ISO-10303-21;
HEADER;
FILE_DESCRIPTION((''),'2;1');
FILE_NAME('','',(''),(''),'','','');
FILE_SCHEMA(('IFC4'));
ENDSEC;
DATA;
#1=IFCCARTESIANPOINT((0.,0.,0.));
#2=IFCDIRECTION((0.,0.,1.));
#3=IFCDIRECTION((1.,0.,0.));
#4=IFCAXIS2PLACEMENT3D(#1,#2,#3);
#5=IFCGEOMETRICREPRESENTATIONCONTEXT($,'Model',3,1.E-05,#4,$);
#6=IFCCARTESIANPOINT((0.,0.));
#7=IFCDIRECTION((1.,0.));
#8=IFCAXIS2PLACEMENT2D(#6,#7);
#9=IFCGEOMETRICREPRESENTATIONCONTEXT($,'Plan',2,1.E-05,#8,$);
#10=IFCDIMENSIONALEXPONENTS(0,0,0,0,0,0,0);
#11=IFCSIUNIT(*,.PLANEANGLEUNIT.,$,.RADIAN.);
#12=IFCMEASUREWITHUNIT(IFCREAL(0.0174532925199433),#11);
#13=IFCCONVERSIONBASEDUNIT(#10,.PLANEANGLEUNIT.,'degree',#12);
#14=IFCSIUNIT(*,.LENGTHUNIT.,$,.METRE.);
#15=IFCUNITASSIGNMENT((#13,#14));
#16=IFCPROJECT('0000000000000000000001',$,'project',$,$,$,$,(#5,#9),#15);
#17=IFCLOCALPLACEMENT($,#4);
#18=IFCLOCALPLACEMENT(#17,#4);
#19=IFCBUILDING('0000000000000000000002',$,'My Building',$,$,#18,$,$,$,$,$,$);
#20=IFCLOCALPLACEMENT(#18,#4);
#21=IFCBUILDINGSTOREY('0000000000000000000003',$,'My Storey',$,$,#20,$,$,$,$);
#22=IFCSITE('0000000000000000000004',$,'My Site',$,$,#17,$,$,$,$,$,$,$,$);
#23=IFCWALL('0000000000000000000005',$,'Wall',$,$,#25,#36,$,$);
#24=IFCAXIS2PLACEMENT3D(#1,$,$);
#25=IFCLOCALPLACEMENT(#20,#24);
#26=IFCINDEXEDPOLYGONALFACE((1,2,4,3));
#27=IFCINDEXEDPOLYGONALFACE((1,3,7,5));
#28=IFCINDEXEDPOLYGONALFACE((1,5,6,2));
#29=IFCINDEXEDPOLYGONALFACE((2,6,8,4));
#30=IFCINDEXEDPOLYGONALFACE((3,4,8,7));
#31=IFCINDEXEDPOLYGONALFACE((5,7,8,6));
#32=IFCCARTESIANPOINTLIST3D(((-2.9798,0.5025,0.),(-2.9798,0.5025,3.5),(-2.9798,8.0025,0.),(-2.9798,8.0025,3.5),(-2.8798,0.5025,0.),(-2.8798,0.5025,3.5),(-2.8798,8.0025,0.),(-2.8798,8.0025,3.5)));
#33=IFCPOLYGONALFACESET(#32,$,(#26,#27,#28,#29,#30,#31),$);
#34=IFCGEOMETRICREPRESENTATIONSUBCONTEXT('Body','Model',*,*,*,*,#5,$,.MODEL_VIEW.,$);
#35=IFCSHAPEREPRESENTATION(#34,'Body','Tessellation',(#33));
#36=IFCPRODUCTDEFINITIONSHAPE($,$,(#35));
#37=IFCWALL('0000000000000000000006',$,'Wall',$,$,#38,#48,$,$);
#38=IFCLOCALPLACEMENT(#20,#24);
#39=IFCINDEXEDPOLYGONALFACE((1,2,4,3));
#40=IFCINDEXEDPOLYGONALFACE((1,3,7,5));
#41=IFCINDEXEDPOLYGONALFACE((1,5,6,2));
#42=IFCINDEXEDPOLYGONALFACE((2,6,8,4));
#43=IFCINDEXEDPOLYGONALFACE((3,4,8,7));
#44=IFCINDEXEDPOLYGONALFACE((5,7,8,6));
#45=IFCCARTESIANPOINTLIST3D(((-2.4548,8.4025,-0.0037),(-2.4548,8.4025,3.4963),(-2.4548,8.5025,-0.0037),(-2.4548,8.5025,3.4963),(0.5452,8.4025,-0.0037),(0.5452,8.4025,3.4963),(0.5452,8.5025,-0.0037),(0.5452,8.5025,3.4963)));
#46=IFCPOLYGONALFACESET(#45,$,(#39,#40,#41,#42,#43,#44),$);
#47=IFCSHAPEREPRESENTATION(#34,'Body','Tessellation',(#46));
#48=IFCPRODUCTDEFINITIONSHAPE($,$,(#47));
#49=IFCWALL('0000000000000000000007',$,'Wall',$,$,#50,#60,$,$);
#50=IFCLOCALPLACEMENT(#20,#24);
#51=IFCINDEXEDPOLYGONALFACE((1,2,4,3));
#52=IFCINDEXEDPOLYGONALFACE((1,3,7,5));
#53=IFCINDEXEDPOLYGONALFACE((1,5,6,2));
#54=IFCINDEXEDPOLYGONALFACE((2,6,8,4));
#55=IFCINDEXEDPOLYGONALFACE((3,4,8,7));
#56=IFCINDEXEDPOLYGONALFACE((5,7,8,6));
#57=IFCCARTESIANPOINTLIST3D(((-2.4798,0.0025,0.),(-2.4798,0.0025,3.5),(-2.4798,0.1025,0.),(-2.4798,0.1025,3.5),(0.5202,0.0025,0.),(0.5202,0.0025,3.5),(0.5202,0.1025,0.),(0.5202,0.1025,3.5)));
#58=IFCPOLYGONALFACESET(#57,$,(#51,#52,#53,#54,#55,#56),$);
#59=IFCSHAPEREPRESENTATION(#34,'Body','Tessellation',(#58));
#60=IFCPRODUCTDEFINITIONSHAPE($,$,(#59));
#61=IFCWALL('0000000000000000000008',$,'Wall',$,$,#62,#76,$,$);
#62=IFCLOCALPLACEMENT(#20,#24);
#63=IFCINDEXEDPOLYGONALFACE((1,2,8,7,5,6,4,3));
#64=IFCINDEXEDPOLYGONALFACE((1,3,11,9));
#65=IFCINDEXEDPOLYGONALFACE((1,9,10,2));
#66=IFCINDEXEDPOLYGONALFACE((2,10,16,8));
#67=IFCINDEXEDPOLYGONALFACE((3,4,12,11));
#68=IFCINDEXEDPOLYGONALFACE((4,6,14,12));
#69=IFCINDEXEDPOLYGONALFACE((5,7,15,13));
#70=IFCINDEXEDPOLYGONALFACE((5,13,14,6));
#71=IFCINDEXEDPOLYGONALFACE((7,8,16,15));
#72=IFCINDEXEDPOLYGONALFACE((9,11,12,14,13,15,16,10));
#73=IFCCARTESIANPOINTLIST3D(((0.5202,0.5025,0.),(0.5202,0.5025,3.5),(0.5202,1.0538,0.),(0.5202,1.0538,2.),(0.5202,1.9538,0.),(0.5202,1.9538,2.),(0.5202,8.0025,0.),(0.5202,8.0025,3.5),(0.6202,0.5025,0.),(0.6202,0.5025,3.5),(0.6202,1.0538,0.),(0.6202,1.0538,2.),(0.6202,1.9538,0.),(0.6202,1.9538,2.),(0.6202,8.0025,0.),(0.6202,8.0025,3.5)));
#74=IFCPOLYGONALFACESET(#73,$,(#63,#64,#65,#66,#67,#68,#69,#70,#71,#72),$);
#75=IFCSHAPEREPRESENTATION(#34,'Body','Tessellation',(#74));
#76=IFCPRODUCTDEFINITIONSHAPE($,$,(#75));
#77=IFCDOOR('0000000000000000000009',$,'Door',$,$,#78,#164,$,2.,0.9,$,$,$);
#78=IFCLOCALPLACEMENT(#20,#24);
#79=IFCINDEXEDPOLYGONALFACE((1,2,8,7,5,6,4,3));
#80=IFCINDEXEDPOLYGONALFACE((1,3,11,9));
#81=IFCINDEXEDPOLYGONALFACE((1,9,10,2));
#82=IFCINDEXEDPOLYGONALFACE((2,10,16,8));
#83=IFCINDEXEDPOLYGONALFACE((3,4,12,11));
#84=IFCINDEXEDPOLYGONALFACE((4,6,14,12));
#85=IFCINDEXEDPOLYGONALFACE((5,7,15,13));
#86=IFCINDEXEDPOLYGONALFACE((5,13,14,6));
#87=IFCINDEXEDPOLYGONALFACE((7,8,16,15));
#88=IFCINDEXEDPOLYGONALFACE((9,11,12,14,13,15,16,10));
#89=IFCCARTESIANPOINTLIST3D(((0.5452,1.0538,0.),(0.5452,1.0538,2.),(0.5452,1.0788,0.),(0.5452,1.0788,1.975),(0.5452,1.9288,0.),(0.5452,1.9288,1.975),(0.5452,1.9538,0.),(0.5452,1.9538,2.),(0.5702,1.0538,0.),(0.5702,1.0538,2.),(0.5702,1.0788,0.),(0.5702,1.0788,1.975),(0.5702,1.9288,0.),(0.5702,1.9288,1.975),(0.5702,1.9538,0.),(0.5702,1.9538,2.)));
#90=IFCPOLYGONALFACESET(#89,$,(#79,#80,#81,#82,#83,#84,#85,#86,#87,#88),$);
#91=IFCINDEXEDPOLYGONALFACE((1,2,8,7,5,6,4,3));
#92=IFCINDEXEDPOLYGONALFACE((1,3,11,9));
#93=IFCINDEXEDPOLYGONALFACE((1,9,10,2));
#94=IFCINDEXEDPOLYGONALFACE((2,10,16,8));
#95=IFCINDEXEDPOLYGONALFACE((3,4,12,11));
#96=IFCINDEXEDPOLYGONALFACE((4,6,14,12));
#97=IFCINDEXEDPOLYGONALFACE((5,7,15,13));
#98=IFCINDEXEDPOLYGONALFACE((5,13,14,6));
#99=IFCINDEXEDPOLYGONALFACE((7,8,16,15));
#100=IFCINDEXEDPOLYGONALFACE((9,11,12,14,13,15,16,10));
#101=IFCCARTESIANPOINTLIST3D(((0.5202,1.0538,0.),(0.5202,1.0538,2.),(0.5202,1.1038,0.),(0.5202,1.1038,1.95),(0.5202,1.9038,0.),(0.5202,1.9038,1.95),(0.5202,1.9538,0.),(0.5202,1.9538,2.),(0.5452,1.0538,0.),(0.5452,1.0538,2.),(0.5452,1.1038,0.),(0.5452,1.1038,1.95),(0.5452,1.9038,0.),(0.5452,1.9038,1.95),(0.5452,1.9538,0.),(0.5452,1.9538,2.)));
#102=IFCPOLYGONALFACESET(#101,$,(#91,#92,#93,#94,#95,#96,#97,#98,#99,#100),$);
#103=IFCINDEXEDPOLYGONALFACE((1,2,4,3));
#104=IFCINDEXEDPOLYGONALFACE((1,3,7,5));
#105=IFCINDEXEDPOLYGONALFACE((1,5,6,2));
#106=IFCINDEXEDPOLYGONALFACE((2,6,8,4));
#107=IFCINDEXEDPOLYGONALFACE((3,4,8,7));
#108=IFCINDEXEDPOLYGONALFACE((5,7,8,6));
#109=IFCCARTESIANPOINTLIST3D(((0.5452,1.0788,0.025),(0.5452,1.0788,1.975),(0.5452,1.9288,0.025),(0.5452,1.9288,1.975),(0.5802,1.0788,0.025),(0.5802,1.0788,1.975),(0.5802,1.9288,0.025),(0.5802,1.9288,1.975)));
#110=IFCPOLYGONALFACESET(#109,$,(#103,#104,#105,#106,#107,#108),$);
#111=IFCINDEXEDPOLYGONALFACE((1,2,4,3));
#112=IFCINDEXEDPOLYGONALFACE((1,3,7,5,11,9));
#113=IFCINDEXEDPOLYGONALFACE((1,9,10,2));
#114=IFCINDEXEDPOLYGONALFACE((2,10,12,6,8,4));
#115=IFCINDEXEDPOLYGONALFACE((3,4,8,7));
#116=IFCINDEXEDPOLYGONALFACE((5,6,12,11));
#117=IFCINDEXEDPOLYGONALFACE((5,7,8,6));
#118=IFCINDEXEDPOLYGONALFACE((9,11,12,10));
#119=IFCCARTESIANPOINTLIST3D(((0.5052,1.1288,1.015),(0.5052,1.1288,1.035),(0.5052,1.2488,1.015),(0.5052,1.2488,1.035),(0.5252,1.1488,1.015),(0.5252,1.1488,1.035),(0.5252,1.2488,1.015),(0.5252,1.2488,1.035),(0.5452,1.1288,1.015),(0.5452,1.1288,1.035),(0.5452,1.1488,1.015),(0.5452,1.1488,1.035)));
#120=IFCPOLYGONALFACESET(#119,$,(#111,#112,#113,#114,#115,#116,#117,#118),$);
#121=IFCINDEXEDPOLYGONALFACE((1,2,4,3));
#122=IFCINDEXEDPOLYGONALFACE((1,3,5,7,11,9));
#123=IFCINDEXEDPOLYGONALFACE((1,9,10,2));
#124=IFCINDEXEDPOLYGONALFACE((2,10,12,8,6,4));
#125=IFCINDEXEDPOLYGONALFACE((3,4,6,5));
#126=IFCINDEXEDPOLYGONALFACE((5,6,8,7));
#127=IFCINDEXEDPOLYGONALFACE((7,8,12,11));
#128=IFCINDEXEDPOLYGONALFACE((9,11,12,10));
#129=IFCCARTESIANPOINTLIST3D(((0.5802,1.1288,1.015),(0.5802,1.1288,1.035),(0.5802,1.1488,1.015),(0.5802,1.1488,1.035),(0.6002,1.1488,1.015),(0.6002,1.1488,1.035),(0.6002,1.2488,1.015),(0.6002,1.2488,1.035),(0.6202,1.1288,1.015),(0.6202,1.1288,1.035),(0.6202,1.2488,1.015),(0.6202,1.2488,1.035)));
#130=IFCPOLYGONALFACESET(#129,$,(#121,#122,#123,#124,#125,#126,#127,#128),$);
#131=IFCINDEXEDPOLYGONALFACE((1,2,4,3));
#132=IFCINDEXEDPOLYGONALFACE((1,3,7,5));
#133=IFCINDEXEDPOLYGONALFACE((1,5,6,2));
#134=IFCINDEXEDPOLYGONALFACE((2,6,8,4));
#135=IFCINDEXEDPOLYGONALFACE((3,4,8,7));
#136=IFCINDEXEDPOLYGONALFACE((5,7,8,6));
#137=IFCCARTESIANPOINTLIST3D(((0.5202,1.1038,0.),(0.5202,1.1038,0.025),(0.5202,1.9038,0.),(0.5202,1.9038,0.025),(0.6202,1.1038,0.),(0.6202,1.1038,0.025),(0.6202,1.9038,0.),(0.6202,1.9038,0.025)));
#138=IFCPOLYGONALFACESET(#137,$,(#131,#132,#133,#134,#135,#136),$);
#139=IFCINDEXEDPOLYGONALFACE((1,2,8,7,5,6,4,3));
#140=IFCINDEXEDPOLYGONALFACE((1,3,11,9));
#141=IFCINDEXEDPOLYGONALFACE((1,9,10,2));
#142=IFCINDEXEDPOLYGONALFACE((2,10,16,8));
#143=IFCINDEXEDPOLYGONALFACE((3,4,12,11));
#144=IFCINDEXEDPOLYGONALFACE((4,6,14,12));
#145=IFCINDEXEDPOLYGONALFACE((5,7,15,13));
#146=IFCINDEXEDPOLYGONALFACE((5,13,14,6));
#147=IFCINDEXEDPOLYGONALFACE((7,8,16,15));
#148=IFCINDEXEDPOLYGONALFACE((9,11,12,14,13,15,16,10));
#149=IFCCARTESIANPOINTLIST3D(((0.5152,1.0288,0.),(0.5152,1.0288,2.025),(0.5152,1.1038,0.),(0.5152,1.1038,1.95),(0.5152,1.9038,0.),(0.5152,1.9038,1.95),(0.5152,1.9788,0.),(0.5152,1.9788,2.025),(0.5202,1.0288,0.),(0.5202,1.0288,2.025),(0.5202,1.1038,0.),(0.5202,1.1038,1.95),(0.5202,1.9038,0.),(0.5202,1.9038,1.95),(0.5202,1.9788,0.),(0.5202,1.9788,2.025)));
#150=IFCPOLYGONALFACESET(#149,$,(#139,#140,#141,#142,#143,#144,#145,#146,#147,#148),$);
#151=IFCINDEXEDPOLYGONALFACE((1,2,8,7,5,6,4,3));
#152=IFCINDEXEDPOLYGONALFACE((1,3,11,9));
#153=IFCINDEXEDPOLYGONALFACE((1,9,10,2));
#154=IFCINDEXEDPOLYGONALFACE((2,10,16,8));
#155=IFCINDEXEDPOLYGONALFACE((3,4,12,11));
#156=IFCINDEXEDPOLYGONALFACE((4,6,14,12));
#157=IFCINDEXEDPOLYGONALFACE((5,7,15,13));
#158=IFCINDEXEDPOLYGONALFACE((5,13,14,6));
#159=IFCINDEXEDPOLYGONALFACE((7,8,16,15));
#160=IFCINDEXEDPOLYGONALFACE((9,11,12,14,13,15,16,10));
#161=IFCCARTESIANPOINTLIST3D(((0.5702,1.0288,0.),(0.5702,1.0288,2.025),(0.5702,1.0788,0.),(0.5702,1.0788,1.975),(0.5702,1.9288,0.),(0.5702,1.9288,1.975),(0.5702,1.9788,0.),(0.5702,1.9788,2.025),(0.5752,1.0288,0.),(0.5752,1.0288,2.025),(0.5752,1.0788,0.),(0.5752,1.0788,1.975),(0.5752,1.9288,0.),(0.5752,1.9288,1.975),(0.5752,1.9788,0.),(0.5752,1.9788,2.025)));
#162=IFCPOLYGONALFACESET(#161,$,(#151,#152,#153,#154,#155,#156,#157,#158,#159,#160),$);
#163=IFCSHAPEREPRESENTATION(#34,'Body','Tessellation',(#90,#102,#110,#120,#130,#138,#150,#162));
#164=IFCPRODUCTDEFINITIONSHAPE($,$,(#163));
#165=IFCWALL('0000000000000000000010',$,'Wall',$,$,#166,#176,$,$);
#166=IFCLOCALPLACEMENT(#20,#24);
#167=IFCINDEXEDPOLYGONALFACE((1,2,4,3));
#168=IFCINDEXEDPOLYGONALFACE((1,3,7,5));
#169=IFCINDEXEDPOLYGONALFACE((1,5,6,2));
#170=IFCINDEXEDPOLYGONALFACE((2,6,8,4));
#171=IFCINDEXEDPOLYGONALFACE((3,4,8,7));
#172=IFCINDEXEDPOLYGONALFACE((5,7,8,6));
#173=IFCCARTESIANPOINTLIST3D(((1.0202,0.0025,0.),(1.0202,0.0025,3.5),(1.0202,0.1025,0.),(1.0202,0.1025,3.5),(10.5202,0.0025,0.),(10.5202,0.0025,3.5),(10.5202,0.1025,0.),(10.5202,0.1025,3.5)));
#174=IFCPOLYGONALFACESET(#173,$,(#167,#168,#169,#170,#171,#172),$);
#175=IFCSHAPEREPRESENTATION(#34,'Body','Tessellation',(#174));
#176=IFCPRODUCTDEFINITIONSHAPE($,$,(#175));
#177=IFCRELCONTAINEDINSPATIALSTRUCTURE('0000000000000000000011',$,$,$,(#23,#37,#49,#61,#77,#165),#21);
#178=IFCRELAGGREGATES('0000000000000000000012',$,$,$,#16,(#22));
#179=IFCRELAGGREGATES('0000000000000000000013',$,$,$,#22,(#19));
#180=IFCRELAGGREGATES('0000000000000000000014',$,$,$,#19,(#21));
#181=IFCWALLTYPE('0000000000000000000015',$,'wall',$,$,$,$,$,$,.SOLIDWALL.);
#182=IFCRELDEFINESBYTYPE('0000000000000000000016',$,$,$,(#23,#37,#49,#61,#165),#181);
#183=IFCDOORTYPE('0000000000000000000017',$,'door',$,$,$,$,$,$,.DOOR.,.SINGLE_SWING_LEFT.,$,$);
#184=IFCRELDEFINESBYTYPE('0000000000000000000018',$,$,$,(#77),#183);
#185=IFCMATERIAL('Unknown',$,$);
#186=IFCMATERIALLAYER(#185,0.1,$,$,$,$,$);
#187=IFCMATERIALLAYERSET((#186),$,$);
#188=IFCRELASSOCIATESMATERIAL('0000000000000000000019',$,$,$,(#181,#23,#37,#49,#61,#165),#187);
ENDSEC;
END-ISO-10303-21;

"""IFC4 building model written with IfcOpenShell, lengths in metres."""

from ifc_helpers import new_model, entity, si_unit, converted_unit, frame, origin_with_axes, origin_2d_with_axis, place, context, subcontext, project, spatial, line, indexed_curve, outline, extrude, shape, source, transform, mapped, material, layer, layer_set, layer_usage, type_object, type_shapes, element, fill, save


model = new_model("IFC4")

# Units and contexts
model_context = context("Model", 3, precision=1e-05, world=origin_with_axes())
plan_context = context("Plan", 2, precision=1e-05, world=origin_2d_with_axis())
body_context_1 = subcontext(model_context, "Body", "Model", "MODEL_VIEW")
body_context_2 = subcontext(plan_context, "Body", "Plan", "PLAN_VIEW")
ifc_project = project(units=[converted_unit("PLANEANGLEUNIT", "degree", entity("IfcReal", 0.0174532925199433), si_unit("PLANEANGLEUNIT", "RADIAN"), dimensions=[0, 0, 0, 0, 0, 0, 0]), si_unit("LENGTHUNIT", "METRE")], contexts=[model_context, plan_context])

# Site, building, storey
site_placement = place(None, origin_with_axes())
site = spatial("IfcSite", under=ifc_project, at=site_placement, Name="My Site")
building_placement = place(site_placement, origin_with_axes())
building = spatial("IfcBuilding", under=site, at=building_placement, Name="My Building")
storey_placement = place(building_placement, origin_with_axes())
storey = spatial("IfcBuildingStorey", under=building, at=storey_placement, Name="My Storey")

# Shared definitions
ifc_material = material(Name="Unknown")

# Walls
ifc_layer_1 = layer(ifc_material, 0.1)
ifc_layer_set_1 = layer_set([ifc_layer_1])
ifc_layer_usage_1 = layer_usage(ifc_layer_set_1, "AXIS2", "POSITIVE", 0.0)
wall_type = type_object("IfcWallType", Name="wall", PredefinedType="SOLIDWALL", material=ifc_layer_set_1)
wall_1_placement = place(storey_placement, frame((-2.9798, 8.0025, 0.0), z_axis=(0.0, 0.0, 1.0), x_axis=(0.0, -1.0, 0.0)))
element("IfcWall", 1, at=wall_1_placement, inside=storey, type_object=wall_type, material=ifc_layer_usage_1, Name="Wall", context=body_context_1, shape_type="SweptSolid", body=[
    extrude(outline(indexed_curve([(0.0, 0.0), (0.0, 0.1), (7.5, 0.1), (7.5, 0.0)], segments=[line(1, 2, 3, 4, 1)])), origin_with_axes(), (0.0, 0.0, 1.0), 3.5),
])
ifc_layer_usage_2 = layer_usage(ifc_layer_set_1, "AXIS2", "POSITIVE", 0.0)
wall_2_placement = place(storey_placement, frame((-2.4548, 8.4025, -0.0037), z_axis=(0.0, 0.0, 1.0), x_axis=(1.0, 0.0, 0.0)))
element("IfcWall", 2, at=wall_2_placement, inside=storey, type_object=wall_type, material=ifc_layer_usage_2, Name="Wall", context=body_context_1, shape_type="SweptSolid", body=[
    extrude(outline(indexed_curve([(0.0, 0.0), (0.0, 0.1), (3.0, 0.1), (3.0, 0.0)], segments=[line(1, 2, 3, 4, 1)])), origin_with_axes(), (0.0, 0.0, 1.0), 3.5),
])
ifc_layer_usage_3 = layer_usage(ifc_layer_set_1, "AXIS2", "POSITIVE", 0.0)
wall_3_placement = place(storey_placement, frame((-2.4798, 0.0025, 0.0), z_axis=(0.0, 0.0, 1.0), x_axis=(1.0, 0.0, 0.0)))
element("IfcWall", 3, at=wall_3_placement, inside=storey, type_object=wall_type, material=ifc_layer_usage_3, Name="Wall", context=body_context_1, shape_type="SweptSolid", body=[
    extrude(outline(indexed_curve([(0.0, 0.0), (0.0, 0.1), (3.0, 0.1), (3.0, 0.0)], segments=[line(1, 2, 3, 4, 1)])), origin_with_axes(), (0.0, 0.0, 1.0), 3.5),
])

# Wall, opening, door
ifc_layer_usage_4 = layer_usage(ifc_layer_set_1, "AXIS2", "POSITIVE", 0.0)
wall_4_placement = place(storey_placement, frame((0.5202, 8.0025, 0.0), z_axis=(0.0, 0.0, 1.0), x_axis=(0.0, -1.0, 0.0)))
wall_4 = element("IfcWall", 4, at=wall_4_placement, inside=storey, type_object=wall_type, material=ifc_layer_usage_4, Name="Wall", context=body_context_1, shape_type="SweptSolid", body=[
    extrude(outline(indexed_curve([(0.0, 0.0), (0.0, 0.1), (7.5, 0.1), (7.5, 0.0)], segments=[line(1, 2, 3, 4, 1)])), origin_with_axes(), (0.0, 0.0, 1.0), 3.5),
])
shared_shape_1 = source(origin_with_axes(), body_context_1, "Body", "SweptSolid", [
    extrude(outline(indexed_curve([(0.0, 0.0), (0.9, 0.0), (0.9, 2.0), (0.0, 2.0)], segments=[line(1, 2, 3, 4, 1)])), frame((0.0, -0.6, 0.0), z_axis=(0.0, -1.0, 0.0), x_axis=(1.0, 0.0, 0.0)), (0.0, 0.0, -1.0), 1.2),
])
opening_1_placement = place(wall_4_placement, frame((6.0486, 0.0, 0.0), z_axis=(0.0, 0.0, 1.0), x_axis=(1.0, 0.0, 0.0)))
opening_1 = element("IfcOpeningElement", 5, at=opening_1_placement, cuts=wall_4, PredefinedType="OPENING", context=body_context_1, shape_type="MappedRepresentation", body=[
    mapped(shared_shape_1, transform((0.0, 0.0, 0.0), x_axis=(1.0, 0.0, 0.0), y_axis=(0.0, 1.0, 0.0), z_axis=(0.0, 0.0, 1.0), scale=1.0)),
])
door_type = type_object("IfcDoorType", Name="door", OperationType="SINGLE_SWING_LEFT", PredefinedType="DOOR")
shared_shape_2 = source(origin_with_axes(), body_context_1, "Body", "SweptSolid", [
    extrude(outline(indexed_curve([(0.0, 0.0), (0.0, 2.0), (0.9, 2.0), (0.9, 0.0), (0.875, 0.0), (0.875, 1.975), (0.025, 1.975), (0.025, 0.0)], segments=[line(1, 2, 3, 4, 5, 6, 7, 8, 1)])), frame((0.0, 0.025, 0.0), z_axis=(0.0, -1.0, 0.0), x_axis=(1.0, 0.0, 0.0)), (0.0, 0.0, -1.0), 0.025),
    extrude(outline(indexed_curve([(0.0, 0.0), (0.0, 2.0), (0.9, 2.0), (0.9, 0.0), (0.85, 0.0), (0.85, 1.95), (0.05, 1.95), (0.05, 0.0)], segments=[line(1, 2, 3, 4, 5, 6, 7, 8, 1)])), frame((0.0, 0.0, 0.0), z_axis=(0.0, -1.0, 0.0), x_axis=(1.0, 0.0, 0.0)), (0.0, 0.0, -1.0), 0.025),
    extrude(outline(indexed_curve([(0.0, 0.0), (0.85, 0.0), (0.85, 0.035), (0.0, 0.035)], segments=[line(1, 2, 3, 4, 1)])), frame((0.025, 0.025, 0.025), z_axis=(0.0, 0.0, 1.0), x_axis=(1.0, 0.0, 0.0)), (0.0, 0.0, 1.0), 1.95),
    extrude(outline(indexed_curve([(0.0, 0.0), (0.0, -0.04), (-0.12, -0.04), (-0.12, -0.02), (-0.02, -0.02), (-0.02, 0.0)], segments=[line(1, 2, 3, 4, 5, 6, 1)])), frame((0.825, 0.025, 1.015), z_axis=(0.0, 0.0, 1.0), x_axis=(1.0, 0.0, 0.0)), (0.0, 0.0, 1.0), 0.02),
    extrude(outline(indexed_curve([(0.0, 0.0), (0.0, 0.04), (-0.12, 0.04), (-0.12, 0.02), (-0.02, 0.02), (-0.02, 0.0)], segments=[line(1, 2, 3, 4, 5, 6, 1)])), frame((0.825, 0.06, 1.015), z_axis=(0.0, 0.0, 1.0), x_axis=(1.0, 0.0, 0.0)), (0.0, 0.0, 1.0), 0.02),
    extrude(outline(indexed_curve([(0.0, 0.0), (0.8, 0.0), (0.8, 0.1), (0.0, 0.1)], segments=[line(1, 2, 3, 4, 1)])), frame((0.05, 0.0, 0.0), z_axis=(0.0, 0.0, 1.0), x_axis=(1.0, 0.0, 0.0)), (0.0, 0.0, 1.0), 0.025),
    extrude(outline(indexed_curve([(0.0, 0.0), (0.0, 2.025), (0.95, 2.025), (0.95, 0.0), (0.875, 0.0), (0.875, 1.95), (0.075, 1.95), (0.075, 0.0)], segments=[line(1, 2, 3, 4, 5, 6, 7, 8, 1)])), frame((-0.025, -0.005, 0.0), z_axis=(0.0, -1.0, 0.0), x_axis=(1.0, 0.0, 0.0)), (0.0, 0.0, -1.0), 0.005),
    extrude(outline(indexed_curve([(0.0, 0.0), (0.0, 2.025), (0.95, 2.025), (0.95, 0.0), (0.9, 0.0), (0.9, 1.975), (0.05, 1.975), (0.05, 0.0)], segments=[line(1, 2, 3, 4, 5, 6, 7, 8, 1)])), frame((-0.025, 0.05, 0.0), z_axis=(0.0, -1.0, 0.0), x_axis=(1.0, 0.0, 0.0)), (0.0, 0.0, -1.0), 0.005),
])
shared_shape_3 = source(origin_with_axes(), body_context_2, "Body", "Curve2D", [
    entity("IfcIndexedPolyCurve", entity("IfcCartesianPointList2D", [[0.0, 0.0], [0.0, 0.05], [0.025, 0.05], [0.025, 0.025], [0.05, 0.025], [0.05, 0.0]]), [entity("IfcLineIndex", [1, 2, 3, 4, 5, 6, 1])]),
    entity("IfcIndexedPolyCurve", entity("IfcCartesianPointList2D", [[0.9, 0.0], [0.9, 0.05], [0.875, 0.05], [0.875, 0.025], [0.85, 0.025], [0.85, 0.0]]), [entity("IfcLineIndex", [1, 2, 3, 4, 5, 6, 1])]),
    entity("IfcTrimmedCurve", entity("IfcEllipse", entity("IfcAxis2Placement2D", entity("IfcCartesianPoint", [0.06, 0.05]), entity("IfcDirection", [1.0, 0.0])), 0.815, 0.85), [entity("IfcCartesianPoint", [0.875, 0.05])], [entity("IfcCartesianPoint", [0.06, 0.9])], True, "CARTESIAN"),
    entity("IfcIndexedPolyCurve", entity("IfcCartesianPointList2D", [[0.025, 0.05], [0.06, 0.05], [0.06, 0.9], [0.025, 0.9]]), [entity("IfcLineIndex", [1, 2, 3, 4, 1])]),
])
type_shapes(door_type, [shared_shape_2, shared_shape_3])
door_1_placement = place(opening_1_placement, frame((0.0, 0.0, 0.0), z_axis=(0.0, 0.0, 1.0), x_axis=(1.0, 0.0, 0.0)))
door_1 = element("IfcDoor", 6, at=door_1_placement, inside=storey, type_object=door_type, Name="Door", OverallHeight=2.0, OverallWidth=0.9, shapes=[
    shape(body_context_1, "Body", "MappedRepresentation", [mapped(shared_shape_2, transform((0.0, 0.0, 0.0), x_axis=(1.0, 0.0, 0.0), y_axis=(0.0, 1.0, 0.0), z_axis=(0.0, 0.0, 1.0), scale=1.0))]),
    shape(body_context_2, "Body", "MappedRepresentation", [mapped(shared_shape_3, transform((0.0, 0.0, 0.0), x_axis=(1.0, 0.0, 0.0), y_axis=(0.0, 1.0, 0.0), z_axis=(0.0, 0.0, 1.0), scale=1.0))]),
])
fill(opening_1, door_1)

# Wall
ifc_layer_usage_5 = layer_usage(ifc_layer_set_1, "AXIS2", "POSITIVE", 0.0)
wall_5_placement = place(storey_placement, frame((1.0202, 0.0025, 0.0), z_axis=(0.0, 0.0, 1.0), x_axis=(1.0, 0.0, 0.0)))
element("IfcWall", 7, at=wall_5_placement, inside=storey, type_object=wall_type, material=ifc_layer_usage_5, Name="Wall", context=body_context_1, shape_type="SweptSolid", body=[
    extrude(outline(indexed_curve([(0.0, 0.0), (0.0, 0.1), (9.5, 0.1), (9.5, 0.0)], segments=[line(1, 2, 3, 4, 1)])), origin_with_axes(), (0.0, 0.0, 1.0), 3.5),
])

save(model, "model.ifc")
